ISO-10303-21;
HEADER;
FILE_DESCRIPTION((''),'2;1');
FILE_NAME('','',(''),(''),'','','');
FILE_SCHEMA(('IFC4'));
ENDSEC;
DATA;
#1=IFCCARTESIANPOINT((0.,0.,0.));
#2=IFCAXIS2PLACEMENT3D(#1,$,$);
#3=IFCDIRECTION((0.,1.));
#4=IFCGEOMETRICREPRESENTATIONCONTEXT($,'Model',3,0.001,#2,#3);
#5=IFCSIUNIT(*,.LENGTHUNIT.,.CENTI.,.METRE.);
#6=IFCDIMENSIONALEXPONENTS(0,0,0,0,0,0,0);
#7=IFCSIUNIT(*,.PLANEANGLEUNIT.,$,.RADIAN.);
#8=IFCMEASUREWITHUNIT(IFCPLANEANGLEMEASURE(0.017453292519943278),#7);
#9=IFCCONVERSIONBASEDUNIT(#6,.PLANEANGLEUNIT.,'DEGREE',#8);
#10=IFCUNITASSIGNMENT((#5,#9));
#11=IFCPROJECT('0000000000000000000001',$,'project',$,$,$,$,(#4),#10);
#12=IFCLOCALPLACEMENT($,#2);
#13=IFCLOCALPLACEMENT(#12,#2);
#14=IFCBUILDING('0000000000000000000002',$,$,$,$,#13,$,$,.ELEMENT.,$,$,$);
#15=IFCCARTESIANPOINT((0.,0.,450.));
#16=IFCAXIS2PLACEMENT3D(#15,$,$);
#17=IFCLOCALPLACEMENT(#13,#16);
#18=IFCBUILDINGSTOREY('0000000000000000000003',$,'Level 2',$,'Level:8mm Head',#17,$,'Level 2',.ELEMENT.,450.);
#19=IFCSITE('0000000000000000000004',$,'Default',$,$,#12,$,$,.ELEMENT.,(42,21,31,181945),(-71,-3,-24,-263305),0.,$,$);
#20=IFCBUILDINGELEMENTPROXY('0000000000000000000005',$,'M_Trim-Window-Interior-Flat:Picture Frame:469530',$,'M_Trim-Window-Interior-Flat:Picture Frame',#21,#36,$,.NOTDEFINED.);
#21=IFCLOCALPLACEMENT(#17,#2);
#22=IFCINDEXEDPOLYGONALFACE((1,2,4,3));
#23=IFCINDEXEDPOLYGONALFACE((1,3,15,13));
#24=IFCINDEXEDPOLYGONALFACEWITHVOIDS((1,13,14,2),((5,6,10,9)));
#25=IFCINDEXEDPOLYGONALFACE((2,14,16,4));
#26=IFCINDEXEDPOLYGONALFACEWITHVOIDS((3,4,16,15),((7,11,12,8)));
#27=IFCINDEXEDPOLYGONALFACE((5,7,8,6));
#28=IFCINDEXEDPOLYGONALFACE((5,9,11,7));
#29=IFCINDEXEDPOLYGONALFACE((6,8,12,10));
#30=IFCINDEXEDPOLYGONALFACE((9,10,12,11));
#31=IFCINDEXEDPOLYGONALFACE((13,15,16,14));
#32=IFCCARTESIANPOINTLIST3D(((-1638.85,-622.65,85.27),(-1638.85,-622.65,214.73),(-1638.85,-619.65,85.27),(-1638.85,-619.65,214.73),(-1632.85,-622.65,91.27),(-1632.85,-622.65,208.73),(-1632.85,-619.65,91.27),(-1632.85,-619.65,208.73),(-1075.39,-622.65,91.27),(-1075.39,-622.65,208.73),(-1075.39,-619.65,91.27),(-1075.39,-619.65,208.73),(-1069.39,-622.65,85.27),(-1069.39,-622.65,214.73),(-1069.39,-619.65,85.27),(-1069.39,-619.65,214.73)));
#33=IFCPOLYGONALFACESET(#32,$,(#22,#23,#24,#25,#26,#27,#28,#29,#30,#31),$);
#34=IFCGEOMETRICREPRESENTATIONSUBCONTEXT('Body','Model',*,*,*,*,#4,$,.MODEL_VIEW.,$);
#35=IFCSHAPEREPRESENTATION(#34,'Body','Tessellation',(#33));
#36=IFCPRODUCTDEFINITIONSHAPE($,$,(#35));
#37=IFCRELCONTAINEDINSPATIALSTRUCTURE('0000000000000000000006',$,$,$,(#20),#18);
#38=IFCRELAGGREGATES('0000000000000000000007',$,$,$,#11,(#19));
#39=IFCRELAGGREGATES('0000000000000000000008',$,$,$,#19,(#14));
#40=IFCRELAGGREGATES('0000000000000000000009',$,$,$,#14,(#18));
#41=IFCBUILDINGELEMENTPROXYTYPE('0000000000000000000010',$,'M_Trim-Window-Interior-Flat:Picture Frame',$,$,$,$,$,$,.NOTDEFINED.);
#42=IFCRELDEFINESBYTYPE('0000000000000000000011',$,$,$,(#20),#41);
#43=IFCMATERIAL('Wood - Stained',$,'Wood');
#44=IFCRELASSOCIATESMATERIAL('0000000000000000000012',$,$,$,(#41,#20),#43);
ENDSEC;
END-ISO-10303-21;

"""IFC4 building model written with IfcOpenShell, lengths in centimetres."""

from ifc_helpers import new_model, entity, si_unit, converted_unit, direction, frame, origin, place, context, subcontext, project, spatial, indexed_curve, outline, extrude, source, transform, mapped, material, type_object, type_shapes, element, save


model = new_model("IFC4")

# Units and contexts
model_context = context("Model", 3, precision=0.001, world=origin(), true_north=direction((0.0, 1.0)))
body_context = subcontext(model_context, "Body", "Model", "MODEL_VIEW")
ifc_project = project(units=[si_unit("LENGTHUNIT", "METRE", prefix="CENTI"), converted_unit("PLANEANGLEUNIT", "DEGREE", entity("IfcPlaneAngleMeasure", 0.017453292519943278), si_unit("PLANEANGLEUNIT", "RADIAN"), dimensions=[0, 0, 0, 0, 0, 0, 0])], contexts=[model_context])

# Site, building, storey
site_placement = place(None, origin())
site = spatial("IfcSite", under=ifc_project, at=site_placement, Name="Default", CompositionType="ELEMENT", RefLatitude=(42, 21, 31, 181945), RefLongitude=(-71, -3, -24, -263305), RefElevation=0.0)
building_placement = place(site_placement, origin())
building = spatial("IfcBuilding", under=site, at=building_placement, CompositionType="ELEMENT")
storey_placement = place(building_placement, frame((0.0, 0.0, 450.0)))
storey = spatial("IfcBuildingStorey", under=building, at=storey_placement, Name="Level 2", ObjectType="Level:8mm Head", LongName="Level 2", CompositionType="ELEMENT", Elevation=450.0)

# Building element proxy
ifc_material_1 = material(Name="Wood - Stained", Category="Wood")
building_element_proxy_type_1 = type_object("IfcBuildingElementProxyType", Name="M_Trim-Window-Interior-Flat:Picture Frame", PredefinedType="NOTDEFINED", material=ifc_material_1)
shared_shape_1 = source(origin(), body_context, "Body", "SweptSolid", [
    extrude(outline(indexed_curve([(-284.73, -64.73), (284.73, -64.73), (284.73, 64.73), (-284.73, 64.73), (-284.73, -64.73)], self_intersect=False), holes=[indexed_curve([(-278.73, -58.73), (-278.73, 58.73), (278.73, 58.73), (278.73, -58.73), (-278.73, -58.73)], self_intersect=False)]), frame((0.0, -60.0, 0.0), z_axis=(0.0, 0.0, 1.0), x_axis=(-1.0, 0.0, 0.0)), (0.0, 0.0, 1.0), 3.0),
])
type_shapes(building_element_proxy_type_1, [shared_shape_1])
for number, where, z_axis, x_axis, name in (
    (1, (-1354.12, -622.65, 210.0), (0.0, 1.0, 0.0), (-1.0, 0.0, 0.0), "M_Trim-Window-Interior-Flat:Picture Frame:469530"),
):
    element("IfcBuildingElementProxy", number, at=place(storey_placement, frame(where, z_axis=z_axis, x_axis=x_axis)), inside=storey, type_object=building_element_proxy_type_1, material=ifc_material_1, Name=name, ObjectType="M_Trim-Window-Interior-Flat:Picture Frame", PredefinedType="NOTDEFINED", context=body_context, shape_type="MappedRepresentation", body=[
        mapped(shared_shape_1, transform((0.0, 0.0, 0.0), scale=1.0)),
    ])

save(model, "model.ifc")
